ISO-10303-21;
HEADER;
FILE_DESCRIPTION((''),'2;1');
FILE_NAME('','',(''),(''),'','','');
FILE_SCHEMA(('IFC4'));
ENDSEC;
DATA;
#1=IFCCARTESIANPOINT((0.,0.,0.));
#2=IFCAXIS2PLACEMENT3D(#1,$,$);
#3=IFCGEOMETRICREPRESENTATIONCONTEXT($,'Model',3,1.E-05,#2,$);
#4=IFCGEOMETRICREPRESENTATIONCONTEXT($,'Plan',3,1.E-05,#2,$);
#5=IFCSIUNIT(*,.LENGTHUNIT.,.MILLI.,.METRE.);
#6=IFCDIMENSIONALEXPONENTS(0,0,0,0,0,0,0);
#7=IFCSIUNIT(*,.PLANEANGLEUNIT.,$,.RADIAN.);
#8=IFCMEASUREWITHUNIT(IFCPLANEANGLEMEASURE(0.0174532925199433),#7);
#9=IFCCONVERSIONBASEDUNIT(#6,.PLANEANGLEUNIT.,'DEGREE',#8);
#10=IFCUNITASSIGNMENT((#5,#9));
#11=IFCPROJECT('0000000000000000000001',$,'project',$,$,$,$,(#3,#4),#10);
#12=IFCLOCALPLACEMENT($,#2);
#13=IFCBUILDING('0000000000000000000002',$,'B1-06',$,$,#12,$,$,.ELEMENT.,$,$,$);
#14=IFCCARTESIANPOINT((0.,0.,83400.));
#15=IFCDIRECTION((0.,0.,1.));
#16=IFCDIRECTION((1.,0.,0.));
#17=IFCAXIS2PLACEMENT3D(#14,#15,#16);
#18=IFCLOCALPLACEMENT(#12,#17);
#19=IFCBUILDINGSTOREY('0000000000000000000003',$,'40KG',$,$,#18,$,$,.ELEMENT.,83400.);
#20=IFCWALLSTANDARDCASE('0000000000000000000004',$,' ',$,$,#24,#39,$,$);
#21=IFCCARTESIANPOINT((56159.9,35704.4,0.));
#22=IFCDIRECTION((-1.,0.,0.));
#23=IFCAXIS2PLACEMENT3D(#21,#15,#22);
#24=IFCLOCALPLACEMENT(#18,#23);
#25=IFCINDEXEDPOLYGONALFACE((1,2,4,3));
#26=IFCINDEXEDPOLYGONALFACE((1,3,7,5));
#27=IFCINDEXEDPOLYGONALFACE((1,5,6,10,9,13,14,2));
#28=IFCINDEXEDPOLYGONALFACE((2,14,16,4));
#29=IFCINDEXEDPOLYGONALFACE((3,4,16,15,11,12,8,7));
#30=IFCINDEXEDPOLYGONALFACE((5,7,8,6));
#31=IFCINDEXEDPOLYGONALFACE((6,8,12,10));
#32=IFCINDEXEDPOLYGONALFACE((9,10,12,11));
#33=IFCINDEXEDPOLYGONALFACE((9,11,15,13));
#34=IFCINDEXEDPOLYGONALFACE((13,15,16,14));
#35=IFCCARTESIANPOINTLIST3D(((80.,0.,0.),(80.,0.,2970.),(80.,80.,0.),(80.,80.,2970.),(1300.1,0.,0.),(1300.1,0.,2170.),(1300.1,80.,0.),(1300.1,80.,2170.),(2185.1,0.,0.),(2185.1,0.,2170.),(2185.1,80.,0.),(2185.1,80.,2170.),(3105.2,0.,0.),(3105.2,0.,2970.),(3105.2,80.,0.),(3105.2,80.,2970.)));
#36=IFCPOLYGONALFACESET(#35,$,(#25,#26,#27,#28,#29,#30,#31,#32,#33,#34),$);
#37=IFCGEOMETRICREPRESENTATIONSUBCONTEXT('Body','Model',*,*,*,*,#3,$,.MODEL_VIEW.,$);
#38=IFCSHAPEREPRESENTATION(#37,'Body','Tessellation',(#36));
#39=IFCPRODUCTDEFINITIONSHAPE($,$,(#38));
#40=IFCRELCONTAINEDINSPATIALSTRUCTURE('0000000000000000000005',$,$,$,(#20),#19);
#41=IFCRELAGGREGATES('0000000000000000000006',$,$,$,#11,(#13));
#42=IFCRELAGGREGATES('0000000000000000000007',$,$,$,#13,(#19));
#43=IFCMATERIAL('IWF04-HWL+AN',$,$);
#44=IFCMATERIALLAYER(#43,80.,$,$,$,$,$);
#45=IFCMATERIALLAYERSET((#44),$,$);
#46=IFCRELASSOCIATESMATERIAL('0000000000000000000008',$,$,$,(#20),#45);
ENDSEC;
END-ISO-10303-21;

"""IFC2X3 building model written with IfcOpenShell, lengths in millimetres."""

from ifc_helpers import new_model, entity, si_unit, converted_unit, frame, frame_2d, origin, origin_with_axes, place, context, subcontext, project, spatial, polyline, rectangle, outline, extrude, material, layer, layer_set, layer_usage, element, save


model = new_model("IFC2X3")

# Units and contexts
model_context = context("Model", 3, precision=1e-05, world=origin())
plan_context = context("Plan", 3, precision=1e-05, world=origin())
body_context = subcontext(model_context, "Body", "Model", "MODEL_VIEW")
ifc_project = project(units=[si_unit("LENGTHUNIT", "METRE", prefix="MILLI"), converted_unit("PLANEANGLEUNIT", "DEGREE", entity("IfcPlaneAngleMeasure", 0.0174532925199433), si_unit("PLANEANGLEUNIT", "RADIAN"), dimensions=[0, 0, 0, 0, 0, 0, 0])], contexts=[model_context, plan_context])

# Building, storey
building_placement = place(None, origin())
building = spatial("IfcBuilding", under=ifc_project, at=building_placement, Name="B1-06", CompositionType="ELEMENT")
storey_placement = place(building_placement, frame((0.0, 0.0, 83400.0), z_axis=(0.0, 0.0, 1.0), x_axis=(1.0, 0.0, 0.0)))
storey = spatial("IfcBuildingStorey", under=building, at=storey_placement, Name="40KG", CompositionType="ELEMENT", Elevation=83400.0)

# Wall, opening
ifc_material_1 = material(Name="IWF04-HWL+AN")
ifc_layer_1 = layer(ifc_material_1, 80.0)
ifc_layer_set_1 = layer_set([ifc_layer_1])
ifc_layer_usage_1 = layer_usage(ifc_layer_set_1, "AXIS2", "POSITIVE", 0.0)
wall_1_placement = place(storey_placement, frame((56159.9, 35704.4, 0.0), z_axis=(0.0, 0.0, 1.0), x_axis=(-1.0, 0.0, 0.0)))
wall_1 = element("IfcWallStandardCase", 1, at=wall_1_placement, inside=storey, material=ifc_layer_usage_1, Name=" ", context=body_context, shape_type="SweptSolid", body=[
    extrude(outline(polyline([(80.0, 0.0), (3185.2, 0.0), (3105.2, 0.0), (3105.2, 80.0), (80.0, 80.0), (80.0, 0.0)])), origin_with_axes(), (0.0, 0.0, 1.0), 2970.0),
])
opening_1_placement = place(wall_1_placement, frame((1300.1, 0.0, 0.0), z_axis=(0.0, 1.0, 0.0), x_axis=(0.0, 0.0, 1.0)))
element("IfcOpeningElement", 2, at=opening_1_placement, cuts=wall_1, ObjectType="Opening", context=body_context, shape_type="SweptSolid", body=[
    extrude(rectangle(XDim=2170.0, YDim=885.0, at=frame_2d((1085.0, 442.5), x_axis=(1.0, 0.0))), origin_with_axes(), (0.0, 0.0, 1.0), 80.0),
])

save(model, "model.ifc")
